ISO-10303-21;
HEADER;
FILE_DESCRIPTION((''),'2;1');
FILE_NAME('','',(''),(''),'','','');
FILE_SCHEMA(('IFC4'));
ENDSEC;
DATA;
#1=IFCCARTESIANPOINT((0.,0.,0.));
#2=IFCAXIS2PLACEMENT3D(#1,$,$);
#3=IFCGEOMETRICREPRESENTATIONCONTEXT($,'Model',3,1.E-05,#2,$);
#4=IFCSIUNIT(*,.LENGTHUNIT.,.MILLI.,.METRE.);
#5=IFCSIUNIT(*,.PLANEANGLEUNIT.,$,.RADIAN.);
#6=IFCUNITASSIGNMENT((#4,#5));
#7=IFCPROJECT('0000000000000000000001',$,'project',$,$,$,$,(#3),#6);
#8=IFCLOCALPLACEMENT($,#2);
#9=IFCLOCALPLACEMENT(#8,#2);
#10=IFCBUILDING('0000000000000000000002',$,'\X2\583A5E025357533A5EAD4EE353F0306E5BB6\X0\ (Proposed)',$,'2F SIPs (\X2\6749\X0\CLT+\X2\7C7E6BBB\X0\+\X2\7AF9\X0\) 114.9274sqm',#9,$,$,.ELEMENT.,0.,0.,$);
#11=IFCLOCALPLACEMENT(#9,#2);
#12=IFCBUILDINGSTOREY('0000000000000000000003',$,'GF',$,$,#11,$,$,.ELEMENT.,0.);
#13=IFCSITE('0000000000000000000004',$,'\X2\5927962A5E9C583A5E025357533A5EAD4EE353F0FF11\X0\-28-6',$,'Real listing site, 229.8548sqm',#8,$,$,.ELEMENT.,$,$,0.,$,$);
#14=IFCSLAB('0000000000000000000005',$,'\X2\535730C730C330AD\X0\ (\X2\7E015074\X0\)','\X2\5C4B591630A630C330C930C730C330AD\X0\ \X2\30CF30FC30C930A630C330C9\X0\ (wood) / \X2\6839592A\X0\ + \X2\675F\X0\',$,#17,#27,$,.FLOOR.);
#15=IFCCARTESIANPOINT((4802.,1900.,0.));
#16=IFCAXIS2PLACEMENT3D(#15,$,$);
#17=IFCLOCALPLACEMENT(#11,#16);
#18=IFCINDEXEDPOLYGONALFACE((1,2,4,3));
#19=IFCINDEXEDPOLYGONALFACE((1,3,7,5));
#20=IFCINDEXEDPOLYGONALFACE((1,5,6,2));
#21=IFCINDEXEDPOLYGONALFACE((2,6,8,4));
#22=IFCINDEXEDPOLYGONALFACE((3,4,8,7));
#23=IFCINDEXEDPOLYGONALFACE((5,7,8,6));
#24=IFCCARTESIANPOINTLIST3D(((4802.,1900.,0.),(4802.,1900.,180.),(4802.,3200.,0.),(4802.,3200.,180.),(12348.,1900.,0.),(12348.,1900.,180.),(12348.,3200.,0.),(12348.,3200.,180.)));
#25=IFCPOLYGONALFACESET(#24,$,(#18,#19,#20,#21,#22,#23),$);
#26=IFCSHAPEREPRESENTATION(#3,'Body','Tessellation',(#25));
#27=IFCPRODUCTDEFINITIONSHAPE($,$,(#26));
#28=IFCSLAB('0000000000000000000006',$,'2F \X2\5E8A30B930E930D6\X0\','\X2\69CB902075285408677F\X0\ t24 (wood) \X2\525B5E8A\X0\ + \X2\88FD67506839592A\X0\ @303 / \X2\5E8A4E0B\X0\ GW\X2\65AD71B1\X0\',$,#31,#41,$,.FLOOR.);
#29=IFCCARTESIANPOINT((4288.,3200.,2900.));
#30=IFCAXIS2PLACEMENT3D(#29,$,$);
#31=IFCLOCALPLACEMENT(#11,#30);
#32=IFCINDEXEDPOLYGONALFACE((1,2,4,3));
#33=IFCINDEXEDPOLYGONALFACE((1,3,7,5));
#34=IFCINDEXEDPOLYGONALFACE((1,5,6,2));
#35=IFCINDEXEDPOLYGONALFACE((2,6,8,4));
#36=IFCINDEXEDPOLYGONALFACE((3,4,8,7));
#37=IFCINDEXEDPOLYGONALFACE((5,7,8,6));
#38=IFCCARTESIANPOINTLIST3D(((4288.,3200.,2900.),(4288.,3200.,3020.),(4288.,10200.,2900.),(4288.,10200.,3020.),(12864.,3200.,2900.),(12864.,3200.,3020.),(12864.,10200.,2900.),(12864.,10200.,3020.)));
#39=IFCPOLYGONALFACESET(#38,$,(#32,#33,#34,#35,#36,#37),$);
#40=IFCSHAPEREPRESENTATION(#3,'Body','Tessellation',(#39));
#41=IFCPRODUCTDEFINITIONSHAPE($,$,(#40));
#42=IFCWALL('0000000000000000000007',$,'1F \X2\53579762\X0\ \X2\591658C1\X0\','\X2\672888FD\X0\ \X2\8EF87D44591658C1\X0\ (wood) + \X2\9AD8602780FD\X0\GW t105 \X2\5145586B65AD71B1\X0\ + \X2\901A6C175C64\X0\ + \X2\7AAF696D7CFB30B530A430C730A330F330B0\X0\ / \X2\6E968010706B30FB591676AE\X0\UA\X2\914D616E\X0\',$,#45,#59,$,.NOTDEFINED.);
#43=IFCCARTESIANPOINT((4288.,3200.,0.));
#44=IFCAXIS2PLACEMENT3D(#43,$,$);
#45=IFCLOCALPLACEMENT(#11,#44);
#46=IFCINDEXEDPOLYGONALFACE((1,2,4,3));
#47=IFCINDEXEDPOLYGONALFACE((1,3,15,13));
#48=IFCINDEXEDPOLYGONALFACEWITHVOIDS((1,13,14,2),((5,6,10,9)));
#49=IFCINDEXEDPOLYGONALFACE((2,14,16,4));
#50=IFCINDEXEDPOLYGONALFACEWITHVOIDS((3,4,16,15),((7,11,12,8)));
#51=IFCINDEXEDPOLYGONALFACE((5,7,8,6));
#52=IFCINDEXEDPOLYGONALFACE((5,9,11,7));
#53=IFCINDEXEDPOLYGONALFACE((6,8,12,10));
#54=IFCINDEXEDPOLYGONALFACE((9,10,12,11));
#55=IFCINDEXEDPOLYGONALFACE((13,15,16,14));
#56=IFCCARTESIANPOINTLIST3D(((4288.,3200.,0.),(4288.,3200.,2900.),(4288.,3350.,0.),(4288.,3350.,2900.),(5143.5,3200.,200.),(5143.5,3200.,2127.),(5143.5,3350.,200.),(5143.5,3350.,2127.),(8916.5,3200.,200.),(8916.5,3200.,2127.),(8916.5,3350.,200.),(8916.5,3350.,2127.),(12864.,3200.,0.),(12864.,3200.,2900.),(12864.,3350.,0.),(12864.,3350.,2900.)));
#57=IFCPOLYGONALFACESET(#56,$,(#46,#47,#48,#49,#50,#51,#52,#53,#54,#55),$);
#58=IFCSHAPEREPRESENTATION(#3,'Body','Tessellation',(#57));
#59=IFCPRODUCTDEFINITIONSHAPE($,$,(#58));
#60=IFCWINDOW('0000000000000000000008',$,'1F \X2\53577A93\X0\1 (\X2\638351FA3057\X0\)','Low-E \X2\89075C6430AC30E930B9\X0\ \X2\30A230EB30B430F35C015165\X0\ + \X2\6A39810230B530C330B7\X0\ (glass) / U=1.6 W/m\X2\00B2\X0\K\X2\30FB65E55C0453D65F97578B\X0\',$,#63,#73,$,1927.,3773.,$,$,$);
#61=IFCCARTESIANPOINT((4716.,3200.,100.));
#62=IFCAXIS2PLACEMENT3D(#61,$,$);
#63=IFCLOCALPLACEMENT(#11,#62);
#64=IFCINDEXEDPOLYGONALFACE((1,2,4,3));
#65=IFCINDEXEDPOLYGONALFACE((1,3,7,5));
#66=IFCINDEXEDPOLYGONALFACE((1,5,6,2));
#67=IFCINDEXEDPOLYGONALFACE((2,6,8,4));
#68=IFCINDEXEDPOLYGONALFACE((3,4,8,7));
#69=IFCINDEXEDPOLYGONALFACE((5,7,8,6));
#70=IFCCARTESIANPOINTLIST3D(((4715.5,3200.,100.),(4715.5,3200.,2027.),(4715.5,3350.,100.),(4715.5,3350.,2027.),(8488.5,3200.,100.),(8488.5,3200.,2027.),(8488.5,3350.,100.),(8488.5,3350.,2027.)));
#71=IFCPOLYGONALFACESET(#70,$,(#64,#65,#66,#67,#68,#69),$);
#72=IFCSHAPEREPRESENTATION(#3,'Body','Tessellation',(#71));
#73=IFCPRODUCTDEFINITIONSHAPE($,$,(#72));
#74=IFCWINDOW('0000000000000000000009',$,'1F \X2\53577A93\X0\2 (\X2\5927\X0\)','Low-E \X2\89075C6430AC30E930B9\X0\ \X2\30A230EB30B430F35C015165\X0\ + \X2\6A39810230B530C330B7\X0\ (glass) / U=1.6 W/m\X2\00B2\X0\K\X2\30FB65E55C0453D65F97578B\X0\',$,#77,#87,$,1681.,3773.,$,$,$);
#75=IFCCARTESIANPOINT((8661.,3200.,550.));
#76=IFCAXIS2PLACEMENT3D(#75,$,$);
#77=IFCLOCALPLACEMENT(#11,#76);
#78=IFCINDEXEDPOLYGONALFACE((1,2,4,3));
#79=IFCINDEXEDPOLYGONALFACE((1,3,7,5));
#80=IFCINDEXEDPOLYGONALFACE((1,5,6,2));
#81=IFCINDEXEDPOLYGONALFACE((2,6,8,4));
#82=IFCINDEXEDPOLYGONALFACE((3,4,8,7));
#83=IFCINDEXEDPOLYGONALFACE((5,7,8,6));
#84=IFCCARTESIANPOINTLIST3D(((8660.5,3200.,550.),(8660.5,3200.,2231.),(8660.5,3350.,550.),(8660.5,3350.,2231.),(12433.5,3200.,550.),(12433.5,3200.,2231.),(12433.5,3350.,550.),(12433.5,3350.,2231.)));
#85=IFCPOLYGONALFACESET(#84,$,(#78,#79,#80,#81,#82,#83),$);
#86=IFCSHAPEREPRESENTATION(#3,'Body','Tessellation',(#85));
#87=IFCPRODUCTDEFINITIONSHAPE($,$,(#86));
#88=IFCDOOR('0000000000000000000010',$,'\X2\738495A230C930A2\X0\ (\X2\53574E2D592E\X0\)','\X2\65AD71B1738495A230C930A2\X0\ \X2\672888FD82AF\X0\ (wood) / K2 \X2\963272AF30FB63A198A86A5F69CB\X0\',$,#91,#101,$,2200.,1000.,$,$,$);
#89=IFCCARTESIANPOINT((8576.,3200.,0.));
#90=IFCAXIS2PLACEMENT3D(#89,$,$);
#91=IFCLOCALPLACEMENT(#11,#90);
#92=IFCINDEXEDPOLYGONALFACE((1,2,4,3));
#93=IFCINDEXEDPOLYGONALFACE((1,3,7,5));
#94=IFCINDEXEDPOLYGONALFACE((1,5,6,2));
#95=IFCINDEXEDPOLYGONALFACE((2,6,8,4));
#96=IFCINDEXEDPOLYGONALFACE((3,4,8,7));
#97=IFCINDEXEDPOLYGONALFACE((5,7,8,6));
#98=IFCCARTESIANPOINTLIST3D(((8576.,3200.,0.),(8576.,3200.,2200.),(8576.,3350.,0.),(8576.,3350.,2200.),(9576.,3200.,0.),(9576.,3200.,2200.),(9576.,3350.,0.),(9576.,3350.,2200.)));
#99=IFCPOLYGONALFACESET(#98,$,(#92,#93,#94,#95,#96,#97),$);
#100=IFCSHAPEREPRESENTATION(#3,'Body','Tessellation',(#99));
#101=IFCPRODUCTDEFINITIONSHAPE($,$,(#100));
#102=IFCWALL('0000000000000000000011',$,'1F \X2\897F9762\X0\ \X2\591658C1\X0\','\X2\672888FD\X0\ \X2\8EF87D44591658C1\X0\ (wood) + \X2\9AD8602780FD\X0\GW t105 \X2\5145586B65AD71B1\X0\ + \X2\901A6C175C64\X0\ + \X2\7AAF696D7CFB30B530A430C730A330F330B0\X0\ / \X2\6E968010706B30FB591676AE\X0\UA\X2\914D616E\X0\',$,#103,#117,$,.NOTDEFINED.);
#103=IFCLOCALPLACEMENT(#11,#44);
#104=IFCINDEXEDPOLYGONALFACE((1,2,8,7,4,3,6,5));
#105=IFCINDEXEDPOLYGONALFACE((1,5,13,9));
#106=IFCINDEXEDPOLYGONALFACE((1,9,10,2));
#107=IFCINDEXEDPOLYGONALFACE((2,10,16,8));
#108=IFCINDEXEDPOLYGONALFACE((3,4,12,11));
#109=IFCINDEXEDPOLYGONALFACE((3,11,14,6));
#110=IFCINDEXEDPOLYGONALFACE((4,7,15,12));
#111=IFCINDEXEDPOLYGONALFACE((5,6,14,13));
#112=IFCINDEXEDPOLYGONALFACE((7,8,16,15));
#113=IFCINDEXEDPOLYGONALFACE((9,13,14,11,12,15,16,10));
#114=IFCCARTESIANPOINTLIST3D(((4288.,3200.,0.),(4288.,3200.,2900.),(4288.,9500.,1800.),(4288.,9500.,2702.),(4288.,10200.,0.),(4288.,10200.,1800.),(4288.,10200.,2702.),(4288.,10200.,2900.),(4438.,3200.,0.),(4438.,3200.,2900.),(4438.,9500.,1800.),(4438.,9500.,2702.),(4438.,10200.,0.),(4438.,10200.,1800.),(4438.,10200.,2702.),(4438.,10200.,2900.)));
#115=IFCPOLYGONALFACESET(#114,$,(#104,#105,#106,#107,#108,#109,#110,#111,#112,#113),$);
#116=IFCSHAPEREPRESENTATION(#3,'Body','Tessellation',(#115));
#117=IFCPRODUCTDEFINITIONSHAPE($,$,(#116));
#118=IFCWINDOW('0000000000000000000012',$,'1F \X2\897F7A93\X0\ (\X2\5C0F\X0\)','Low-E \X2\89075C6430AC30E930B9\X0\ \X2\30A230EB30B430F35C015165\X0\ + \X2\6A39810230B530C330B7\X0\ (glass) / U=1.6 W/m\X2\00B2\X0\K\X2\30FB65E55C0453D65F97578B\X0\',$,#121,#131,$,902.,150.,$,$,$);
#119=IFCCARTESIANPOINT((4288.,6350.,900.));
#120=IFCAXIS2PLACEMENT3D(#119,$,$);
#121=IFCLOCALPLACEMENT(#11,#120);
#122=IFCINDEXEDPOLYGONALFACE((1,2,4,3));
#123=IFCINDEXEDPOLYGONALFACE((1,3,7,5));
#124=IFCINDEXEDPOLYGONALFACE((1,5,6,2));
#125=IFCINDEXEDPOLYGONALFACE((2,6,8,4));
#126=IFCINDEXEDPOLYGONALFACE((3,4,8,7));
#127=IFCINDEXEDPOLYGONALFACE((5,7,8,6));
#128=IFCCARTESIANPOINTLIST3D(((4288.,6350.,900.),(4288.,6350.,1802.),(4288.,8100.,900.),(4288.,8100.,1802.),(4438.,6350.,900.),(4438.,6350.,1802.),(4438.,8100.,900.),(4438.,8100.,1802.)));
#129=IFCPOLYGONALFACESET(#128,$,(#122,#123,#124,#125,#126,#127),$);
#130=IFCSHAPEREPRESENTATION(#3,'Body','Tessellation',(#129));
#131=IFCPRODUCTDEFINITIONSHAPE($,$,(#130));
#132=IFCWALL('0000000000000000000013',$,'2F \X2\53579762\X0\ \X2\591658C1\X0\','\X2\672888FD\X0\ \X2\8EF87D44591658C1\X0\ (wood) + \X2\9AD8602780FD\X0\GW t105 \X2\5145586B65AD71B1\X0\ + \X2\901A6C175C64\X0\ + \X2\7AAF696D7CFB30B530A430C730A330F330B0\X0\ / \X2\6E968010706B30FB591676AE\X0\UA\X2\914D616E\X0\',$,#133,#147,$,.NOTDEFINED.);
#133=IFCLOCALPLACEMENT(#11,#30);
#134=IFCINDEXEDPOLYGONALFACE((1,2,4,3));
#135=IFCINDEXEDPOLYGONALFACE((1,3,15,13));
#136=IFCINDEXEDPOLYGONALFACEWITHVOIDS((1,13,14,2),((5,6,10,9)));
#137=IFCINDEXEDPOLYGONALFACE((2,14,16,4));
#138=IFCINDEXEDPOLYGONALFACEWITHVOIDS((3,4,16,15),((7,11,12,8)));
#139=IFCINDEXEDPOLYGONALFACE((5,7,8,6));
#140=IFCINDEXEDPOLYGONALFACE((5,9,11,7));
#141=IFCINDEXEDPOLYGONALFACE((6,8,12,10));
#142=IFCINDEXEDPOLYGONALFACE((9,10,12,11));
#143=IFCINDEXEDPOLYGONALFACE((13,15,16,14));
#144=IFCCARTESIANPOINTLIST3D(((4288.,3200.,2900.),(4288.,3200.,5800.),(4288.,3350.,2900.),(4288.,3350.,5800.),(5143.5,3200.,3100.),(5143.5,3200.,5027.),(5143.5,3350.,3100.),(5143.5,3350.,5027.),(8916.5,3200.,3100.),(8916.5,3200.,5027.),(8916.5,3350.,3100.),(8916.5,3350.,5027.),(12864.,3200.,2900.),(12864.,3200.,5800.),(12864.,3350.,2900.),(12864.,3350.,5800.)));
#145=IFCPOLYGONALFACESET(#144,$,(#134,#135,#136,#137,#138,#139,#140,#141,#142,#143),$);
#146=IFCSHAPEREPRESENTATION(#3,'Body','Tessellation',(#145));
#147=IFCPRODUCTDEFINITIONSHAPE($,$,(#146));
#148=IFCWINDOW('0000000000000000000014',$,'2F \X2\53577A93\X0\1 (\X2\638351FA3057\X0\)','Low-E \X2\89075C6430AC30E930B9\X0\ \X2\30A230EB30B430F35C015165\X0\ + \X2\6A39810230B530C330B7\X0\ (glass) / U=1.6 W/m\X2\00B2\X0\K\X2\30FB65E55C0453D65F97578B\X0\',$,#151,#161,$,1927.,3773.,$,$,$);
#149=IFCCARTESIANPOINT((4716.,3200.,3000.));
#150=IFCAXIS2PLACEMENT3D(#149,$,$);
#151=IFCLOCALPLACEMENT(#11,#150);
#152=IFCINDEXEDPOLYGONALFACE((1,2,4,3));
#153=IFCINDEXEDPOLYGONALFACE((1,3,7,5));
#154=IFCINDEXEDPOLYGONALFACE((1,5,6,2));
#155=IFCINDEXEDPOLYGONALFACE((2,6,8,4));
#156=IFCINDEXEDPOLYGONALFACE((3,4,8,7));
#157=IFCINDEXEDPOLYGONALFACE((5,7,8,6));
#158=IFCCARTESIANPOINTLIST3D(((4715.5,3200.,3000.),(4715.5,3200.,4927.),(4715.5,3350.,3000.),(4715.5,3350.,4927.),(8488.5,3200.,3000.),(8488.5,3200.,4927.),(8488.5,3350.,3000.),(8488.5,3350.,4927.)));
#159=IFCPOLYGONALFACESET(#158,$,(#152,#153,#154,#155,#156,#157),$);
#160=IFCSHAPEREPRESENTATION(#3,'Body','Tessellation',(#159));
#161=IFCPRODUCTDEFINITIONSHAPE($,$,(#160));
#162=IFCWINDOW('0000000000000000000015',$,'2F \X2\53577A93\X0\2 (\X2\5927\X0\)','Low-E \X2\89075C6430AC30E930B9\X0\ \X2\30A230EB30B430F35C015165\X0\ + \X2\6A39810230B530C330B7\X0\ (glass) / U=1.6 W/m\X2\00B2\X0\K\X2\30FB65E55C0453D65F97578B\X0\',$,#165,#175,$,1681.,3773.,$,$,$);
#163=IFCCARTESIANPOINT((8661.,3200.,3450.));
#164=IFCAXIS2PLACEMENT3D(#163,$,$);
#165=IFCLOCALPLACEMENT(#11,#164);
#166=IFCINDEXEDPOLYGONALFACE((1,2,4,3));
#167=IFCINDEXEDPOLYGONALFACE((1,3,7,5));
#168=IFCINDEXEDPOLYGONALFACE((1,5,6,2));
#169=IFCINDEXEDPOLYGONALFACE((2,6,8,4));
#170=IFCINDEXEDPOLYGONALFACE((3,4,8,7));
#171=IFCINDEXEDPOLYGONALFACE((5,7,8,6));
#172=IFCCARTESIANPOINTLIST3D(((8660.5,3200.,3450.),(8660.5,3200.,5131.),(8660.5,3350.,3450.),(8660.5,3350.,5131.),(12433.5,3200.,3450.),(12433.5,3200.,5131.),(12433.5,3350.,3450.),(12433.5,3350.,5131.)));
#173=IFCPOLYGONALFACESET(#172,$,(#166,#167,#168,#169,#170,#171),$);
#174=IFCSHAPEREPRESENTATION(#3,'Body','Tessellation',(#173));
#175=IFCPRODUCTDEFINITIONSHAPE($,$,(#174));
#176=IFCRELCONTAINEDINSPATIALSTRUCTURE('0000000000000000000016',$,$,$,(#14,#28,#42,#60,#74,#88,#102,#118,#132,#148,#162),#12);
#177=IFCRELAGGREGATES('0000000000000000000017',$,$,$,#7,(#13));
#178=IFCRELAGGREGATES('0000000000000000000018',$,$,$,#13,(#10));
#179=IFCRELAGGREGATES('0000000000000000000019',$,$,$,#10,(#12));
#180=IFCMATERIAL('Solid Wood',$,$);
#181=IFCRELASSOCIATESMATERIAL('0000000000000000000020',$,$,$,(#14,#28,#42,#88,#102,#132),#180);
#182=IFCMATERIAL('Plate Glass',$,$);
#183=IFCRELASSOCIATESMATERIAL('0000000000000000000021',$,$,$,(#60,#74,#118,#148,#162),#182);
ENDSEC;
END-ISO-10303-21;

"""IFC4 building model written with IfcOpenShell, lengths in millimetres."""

from ifc_helpers import new_model, si_unit, frame, frame_2d, origin, place, context, project, spatial, rectangle, extrude, material, element, fill, save


model = new_model("IFC4")

# Units and contexts
model_context = context("Model", 3, precision=1e-05, world=origin())
ifc_project = project(units=[si_unit("LENGTHUNIT", "METRE", prefix="MILLI"), si_unit("PLANEANGLEUNIT", "RADIAN")], contexts=[model_context])

# Site, building, storey
site_placement = place(None, origin())
site = spatial("IfcSite", under=ifc_project, at=site_placement, Name="大阪府堺市南区庭代台１-28-6", ObjectType="Real listing site, 229.8548sqm", CompositionType="ELEMENT", RefElevation=0.0)
building_placement = place(site_placement, origin())
building = spatial("IfcBuilding", under=site, at=building_placement, Name="堺市南区庭代台の家 (Proposed)", ObjectType="2F SIPs (杉CLT+籾殻+竹) 114.9274sqm", CompositionType="ELEMENT", ElevationOfRefHeight=0.0, ElevationOfTerrain=0.0)
storey_placement = place(building_placement, origin())
storey = spatial("IfcBuildingStorey", under=building, at=storey_placement, Name="GF", CompositionType="ELEMENT", Elevation=0.0)

# Slabs
ifc_material_1 = material(Name="Solid Wood")
slab_1_placement = place(storey_placement, frame((4802.0, 1900.0, 0.0)))
element("IfcSlab", 1, at=slab_1_placement, inside=storey, material=ifc_material_1, Name="南デッキ (縁側)", Description="屋外ウッドデッキ ハードウッド (wood) / 根太 + 束", PredefinedType="FLOOR", context=model_context, shape_type="SweptSolid", body=[
    extrude(rectangle(XDim=7546.0, YDim=1300.0, at=frame_2d((3773.0, 650.0))), frame((4802.0, 1900.0, 0.0)), (0.0, 0.0, 1.0), 180.0),
])
slab_2_placement = place(storey_placement, frame((4288.0, 3200.0, 2900.0)))
element("IfcSlab", 2, at=slab_2_placement, inside=storey, material=ifc_material_1, Name="2F 床スラブ", Description="構造用合板 t24 (wood) 剛床 + 製材根太 @303 / 床下 GW断熱", PredefinedType="FLOOR", context=model_context, shape_type="SweptSolid", body=[
    extrude(rectangle(XDim=8576.0, YDim=7000.0, at=frame_2d((4288.0, 3500.0))), frame((4288.0, 3200.0, 2900.0)), (0.0, 0.0, 1.0), 120.0),
])

# Wall, openings, windows, door
wall_1_placement = place(storey_placement, frame((4288.0, 3200.0, 0.0)))
wall_1 = element("IfcWall", 3, at=wall_1_placement, inside=storey, material=ifc_material_1, Name="1F 南面 外壁", Description="木製 軸組外壁 (wood) + 高性能GW t105 充填断熱 + 通気層 + 窯業系サイディング / 準耐火・外皮UA配慮", PredefinedType="NOTDEFINED", context=model_context, shape_type="SweptSolid", body=[
    extrude(rectangle(XDim=8576.0, YDim=150.0, at=frame_2d((4288.0, 75.0))), frame((4288.0, 3200.0, 0.0)), (0.0, 0.0, 1.0), 2900.0),
])
opening_1_placement = place(storey_placement, frame((4716.0, 3200.0, 100.0)))
opening_1 = element("IfcOpeningElement", 4, at=opening_1_placement, cuts=wall_1, PredefinedType="NOTDEFINED", context=model_context, shape_type="SweptSolid", body=[
    extrude(rectangle(XDim=3773.0, YDim=150.0, at=frame_2d((1886.0, 75.0))), frame((4716.0, 3200.0, 100.0)), (0.0, 0.0, 1.0), 1927.0),
])
opening_2_placement = place(storey_placement, frame((8661.0, 3200.0, 550.0)))
opening_2 = element("IfcOpeningElement", 5, at=opening_2_placement, cuts=wall_1, PredefinedType="NOTDEFINED", context=model_context, shape_type="SweptSolid", body=[
    extrude(rectangle(XDim=3773.0, YDim=150.0, at=frame_2d((1886.0, 75.0))), frame((8661.0, 3200.0, 550.0)), (0.0, 0.0, 1.0), 1681.0),
])
opening_3_placement = place(storey_placement, frame((8576.0, 3200.0, 0.0)))
opening_3 = element("IfcOpeningElement", 6, at=opening_3_placement, cuts=wall_1, PredefinedType="NOTDEFINED", context=model_context, shape_type="SweptSolid", body=[
    extrude(rectangle(XDim=1000.0, YDim=150.0, at=frame_2d((500.0, 75.0))), frame((8576.0, 3200.0, 0.0)), (0.0, 0.0, 1.0), 2200.0),
])
ifc_material_2 = material(Name="Plate Glass")
window_1_placement = place(storey_placement, frame((4716.0, 3200.0, 100.0)))
window_1 = element("IfcWindow", 7, at=window_1_placement, inside=storey, material=ifc_material_2, Name="1F 南窓1 (掃出し)", Description="Low-E 複層ガラス アルゴン封入 + 樹脂サッシ (glass) / U=1.6 W/m²K・日射取得型", OverallHeight=1927.0, OverallWidth=3773.0, context=model_context, shape_type="SweptSolid", body=[
    extrude(rectangle(XDim=3773.0, YDim=150.0, at=frame_2d((1886.0, 75.0))), frame((4716.0, 3200.0, 100.0)), (0.0, 0.0, 1.0), 1927.0),
])
fill(opening_1, window_1)
window_2_placement = place(storey_placement, frame((8661.0, 3200.0, 550.0)))
window_2 = element("IfcWindow", 8, at=window_2_placement, inside=storey, material=ifc_material_2, Name="1F 南窓2 (大)", Description="Low-E 複層ガラス アルゴン封入 + 樹脂サッシ (glass) / U=1.6 W/m²K・日射取得型", OverallHeight=1681.0, OverallWidth=3773.0, context=model_context, shape_type="SweptSolid", body=[
    extrude(rectangle(XDim=3773.0, YDim=150.0, at=frame_2d((1886.0, 75.0))), frame((8661.0, 3200.0, 550.0)), (0.0, 0.0, 1.0), 1681.0),
])
fill(opening_2, window_2)
door_placement = place(storey_placement, frame((8576.0, 3200.0, 0.0)))
door = element("IfcDoor", 9, at=door_placement, inside=storey, material=ifc_material_1, Name="玄関ドア (南中央)", Description="断熱玄関ドア 木製芯 (wood) / K2 防犯・採風機構", OverallHeight=2200.0, OverallWidth=1000.0, context=model_context, shape_type="SweptSolid", body=[
    extrude(rectangle(XDim=1000.0, YDim=150.0, at=frame_2d((500.0, 75.0))), frame((8576.0, 3200.0, 0.0)), (0.0, 0.0, 1.0), 2200.0),
])
fill(opening_3, door)

# Wall, opening, window
wall_2_placement = place(storey_placement, frame((4288.0, 3200.0, 0.0)))
wall_2 = element("IfcWall", 10, at=wall_2_placement, inside=storey, material=ifc_material_1, Name="1F 西面 外壁", Description="木製 軸組外壁 (wood) + 高性能GW t105 充填断熱 + 通気層 + 窯業系サイディング / 準耐火・外皮UA配慮", PredefinedType="NOTDEFINED", context=model_context, shape_type="SweptSolid", body=[
    extrude(rectangle(XDim=150.0, YDim=7000.0, at=frame_2d((75.0, 3500.0))), frame((4288.0, 3200.0, 0.0)), (0.0, 0.0, 1.0), 2900.0),
])
opening_4_placement = place(storey_placement, frame((4288.0, 6350.0, 900.0)))
opening_4 = element("IfcOpeningElement", 11, at=opening_4_placement, cuts=wall_2, PredefinedType="NOTDEFINED", context=model_context, shape_type="SweptSolid", body=[
    extrude(rectangle(XDim=150.0, YDim=1750.0, at=frame_2d((75.0, 875.0))), frame((4288.0, 6350.0, 900.0)), (0.0, 0.0, 1.0), 902.0),
])
window_3_placement = place(storey_placement, frame((4288.0, 6350.0, 900.0)))
window_3 = element("IfcWindow", 12, at=window_3_placement, inside=storey, material=ifc_material_2, Name="1F 西窓 (小)", Description="Low-E 複層ガラス アルゴン封入 + 樹脂サッシ (glass) / U=1.6 W/m²K・日射取得型", OverallHeight=902.0, OverallWidth=150.0, context=model_context, shape_type="SweptSolid", body=[
    extrude(rectangle(XDim=150.0, YDim=1750.0, at=frame_2d((75.0, 875.0))), frame((4288.0, 6350.0, 900.0)), (0.0, 0.0, 1.0), 902.0),
])
fill(opening_4, window_3)

# Wall, openings, windows
wall_3_placement = place(storey_placement, frame((4288.0, 3200.0, 2900.0)))
wall_3 = element("IfcWall", 13, at=wall_3_placement, inside=storey, material=ifc_material_1, Name="2F 南面 外壁", Description="木製 軸組外壁 (wood) + 高性能GW t105 充填断熱 + 通気層 + 窯業系サイディング / 準耐火・外皮UA配慮", PredefinedType="NOTDEFINED", context=model_context, shape_type="SweptSolid", body=[
    extrude(rectangle(XDim=8576.0, YDim=150.0, at=frame_2d((4288.0, 75.0))), frame((4288.0, 3200.0, 2900.0)), (0.0, 0.0, 1.0), 2900.0),
])
opening_5_placement = place(storey_placement, frame((4716.0, 3200.0, 3000.0)))
opening_5 = element("IfcOpeningElement", 14, at=opening_5_placement, cuts=wall_3, PredefinedType="NOTDEFINED", context=model_context, shape_type="SweptSolid", body=[
    extrude(rectangle(XDim=3773.0, YDim=150.0, at=frame_2d((1886.0, 75.0))), frame((4716.0, 3200.0, 3000.0)), (0.0, 0.0, 1.0), 1927.0),
])
opening_6_placement = place(storey_placement, frame((8661.0, 3200.0, 3450.0)))
opening_6 = element("IfcOpeningElement", 15, at=opening_6_placement, cuts=wall_3, PredefinedType="NOTDEFINED", context=model_context, shape_type="SweptSolid", body=[
    extrude(rectangle(XDim=3773.0, YDim=150.0, at=frame_2d((1886.0, 75.0))), frame((8661.0, 3200.0, 3450.0)), (0.0, 0.0, 1.0), 1681.0),
])
window_4_placement = place(storey_placement, frame((4716.0, 3200.0, 3000.0)))
window_4 = element("IfcWindow", 16, at=window_4_placement, inside=storey, material=ifc_material_2, Name="2F 南窓1 (掃出し)", Description="Low-E 複層ガラス アルゴン封入 + 樹脂サッシ (glass) / U=1.6 W/m²K・日射取得型", OverallHeight=1927.0, OverallWidth=3773.0, context=model_context, shape_type="SweptSolid", body=[
    extrude(rectangle(XDim=3773.0, YDim=150.0, at=frame_2d((1886.0, 75.0))), frame((4716.0, 3200.0, 3000.0)), (0.0, 0.0, 1.0), 1927.0),
])
fill(opening_5, window_4)
window_5_placement = place(storey_placement, frame((8661.0, 3200.0, 3450.0)))
window_5 = element("IfcWindow", 17, at=window_5_placement, inside=storey, material=ifc_material_2, Name="2F 南窓2 (大)", Description="Low-E 複層ガラス アルゴン封入 + 樹脂サッシ (glass) / U=1.6 W/m²K・日射取得型", OverallHeight=1681.0, OverallWidth=3773.0, context=model_context, shape_type="SweptSolid", body=[
    extrude(rectangle(XDim=3773.0, YDim=150.0, at=frame_2d((1886.0, 75.0))), frame((8661.0, 3200.0, 3450.0)), (0.0, 0.0, 1.0), 1681.0),
])
fill(opening_6, window_5)

save(model, "model.ifc")
